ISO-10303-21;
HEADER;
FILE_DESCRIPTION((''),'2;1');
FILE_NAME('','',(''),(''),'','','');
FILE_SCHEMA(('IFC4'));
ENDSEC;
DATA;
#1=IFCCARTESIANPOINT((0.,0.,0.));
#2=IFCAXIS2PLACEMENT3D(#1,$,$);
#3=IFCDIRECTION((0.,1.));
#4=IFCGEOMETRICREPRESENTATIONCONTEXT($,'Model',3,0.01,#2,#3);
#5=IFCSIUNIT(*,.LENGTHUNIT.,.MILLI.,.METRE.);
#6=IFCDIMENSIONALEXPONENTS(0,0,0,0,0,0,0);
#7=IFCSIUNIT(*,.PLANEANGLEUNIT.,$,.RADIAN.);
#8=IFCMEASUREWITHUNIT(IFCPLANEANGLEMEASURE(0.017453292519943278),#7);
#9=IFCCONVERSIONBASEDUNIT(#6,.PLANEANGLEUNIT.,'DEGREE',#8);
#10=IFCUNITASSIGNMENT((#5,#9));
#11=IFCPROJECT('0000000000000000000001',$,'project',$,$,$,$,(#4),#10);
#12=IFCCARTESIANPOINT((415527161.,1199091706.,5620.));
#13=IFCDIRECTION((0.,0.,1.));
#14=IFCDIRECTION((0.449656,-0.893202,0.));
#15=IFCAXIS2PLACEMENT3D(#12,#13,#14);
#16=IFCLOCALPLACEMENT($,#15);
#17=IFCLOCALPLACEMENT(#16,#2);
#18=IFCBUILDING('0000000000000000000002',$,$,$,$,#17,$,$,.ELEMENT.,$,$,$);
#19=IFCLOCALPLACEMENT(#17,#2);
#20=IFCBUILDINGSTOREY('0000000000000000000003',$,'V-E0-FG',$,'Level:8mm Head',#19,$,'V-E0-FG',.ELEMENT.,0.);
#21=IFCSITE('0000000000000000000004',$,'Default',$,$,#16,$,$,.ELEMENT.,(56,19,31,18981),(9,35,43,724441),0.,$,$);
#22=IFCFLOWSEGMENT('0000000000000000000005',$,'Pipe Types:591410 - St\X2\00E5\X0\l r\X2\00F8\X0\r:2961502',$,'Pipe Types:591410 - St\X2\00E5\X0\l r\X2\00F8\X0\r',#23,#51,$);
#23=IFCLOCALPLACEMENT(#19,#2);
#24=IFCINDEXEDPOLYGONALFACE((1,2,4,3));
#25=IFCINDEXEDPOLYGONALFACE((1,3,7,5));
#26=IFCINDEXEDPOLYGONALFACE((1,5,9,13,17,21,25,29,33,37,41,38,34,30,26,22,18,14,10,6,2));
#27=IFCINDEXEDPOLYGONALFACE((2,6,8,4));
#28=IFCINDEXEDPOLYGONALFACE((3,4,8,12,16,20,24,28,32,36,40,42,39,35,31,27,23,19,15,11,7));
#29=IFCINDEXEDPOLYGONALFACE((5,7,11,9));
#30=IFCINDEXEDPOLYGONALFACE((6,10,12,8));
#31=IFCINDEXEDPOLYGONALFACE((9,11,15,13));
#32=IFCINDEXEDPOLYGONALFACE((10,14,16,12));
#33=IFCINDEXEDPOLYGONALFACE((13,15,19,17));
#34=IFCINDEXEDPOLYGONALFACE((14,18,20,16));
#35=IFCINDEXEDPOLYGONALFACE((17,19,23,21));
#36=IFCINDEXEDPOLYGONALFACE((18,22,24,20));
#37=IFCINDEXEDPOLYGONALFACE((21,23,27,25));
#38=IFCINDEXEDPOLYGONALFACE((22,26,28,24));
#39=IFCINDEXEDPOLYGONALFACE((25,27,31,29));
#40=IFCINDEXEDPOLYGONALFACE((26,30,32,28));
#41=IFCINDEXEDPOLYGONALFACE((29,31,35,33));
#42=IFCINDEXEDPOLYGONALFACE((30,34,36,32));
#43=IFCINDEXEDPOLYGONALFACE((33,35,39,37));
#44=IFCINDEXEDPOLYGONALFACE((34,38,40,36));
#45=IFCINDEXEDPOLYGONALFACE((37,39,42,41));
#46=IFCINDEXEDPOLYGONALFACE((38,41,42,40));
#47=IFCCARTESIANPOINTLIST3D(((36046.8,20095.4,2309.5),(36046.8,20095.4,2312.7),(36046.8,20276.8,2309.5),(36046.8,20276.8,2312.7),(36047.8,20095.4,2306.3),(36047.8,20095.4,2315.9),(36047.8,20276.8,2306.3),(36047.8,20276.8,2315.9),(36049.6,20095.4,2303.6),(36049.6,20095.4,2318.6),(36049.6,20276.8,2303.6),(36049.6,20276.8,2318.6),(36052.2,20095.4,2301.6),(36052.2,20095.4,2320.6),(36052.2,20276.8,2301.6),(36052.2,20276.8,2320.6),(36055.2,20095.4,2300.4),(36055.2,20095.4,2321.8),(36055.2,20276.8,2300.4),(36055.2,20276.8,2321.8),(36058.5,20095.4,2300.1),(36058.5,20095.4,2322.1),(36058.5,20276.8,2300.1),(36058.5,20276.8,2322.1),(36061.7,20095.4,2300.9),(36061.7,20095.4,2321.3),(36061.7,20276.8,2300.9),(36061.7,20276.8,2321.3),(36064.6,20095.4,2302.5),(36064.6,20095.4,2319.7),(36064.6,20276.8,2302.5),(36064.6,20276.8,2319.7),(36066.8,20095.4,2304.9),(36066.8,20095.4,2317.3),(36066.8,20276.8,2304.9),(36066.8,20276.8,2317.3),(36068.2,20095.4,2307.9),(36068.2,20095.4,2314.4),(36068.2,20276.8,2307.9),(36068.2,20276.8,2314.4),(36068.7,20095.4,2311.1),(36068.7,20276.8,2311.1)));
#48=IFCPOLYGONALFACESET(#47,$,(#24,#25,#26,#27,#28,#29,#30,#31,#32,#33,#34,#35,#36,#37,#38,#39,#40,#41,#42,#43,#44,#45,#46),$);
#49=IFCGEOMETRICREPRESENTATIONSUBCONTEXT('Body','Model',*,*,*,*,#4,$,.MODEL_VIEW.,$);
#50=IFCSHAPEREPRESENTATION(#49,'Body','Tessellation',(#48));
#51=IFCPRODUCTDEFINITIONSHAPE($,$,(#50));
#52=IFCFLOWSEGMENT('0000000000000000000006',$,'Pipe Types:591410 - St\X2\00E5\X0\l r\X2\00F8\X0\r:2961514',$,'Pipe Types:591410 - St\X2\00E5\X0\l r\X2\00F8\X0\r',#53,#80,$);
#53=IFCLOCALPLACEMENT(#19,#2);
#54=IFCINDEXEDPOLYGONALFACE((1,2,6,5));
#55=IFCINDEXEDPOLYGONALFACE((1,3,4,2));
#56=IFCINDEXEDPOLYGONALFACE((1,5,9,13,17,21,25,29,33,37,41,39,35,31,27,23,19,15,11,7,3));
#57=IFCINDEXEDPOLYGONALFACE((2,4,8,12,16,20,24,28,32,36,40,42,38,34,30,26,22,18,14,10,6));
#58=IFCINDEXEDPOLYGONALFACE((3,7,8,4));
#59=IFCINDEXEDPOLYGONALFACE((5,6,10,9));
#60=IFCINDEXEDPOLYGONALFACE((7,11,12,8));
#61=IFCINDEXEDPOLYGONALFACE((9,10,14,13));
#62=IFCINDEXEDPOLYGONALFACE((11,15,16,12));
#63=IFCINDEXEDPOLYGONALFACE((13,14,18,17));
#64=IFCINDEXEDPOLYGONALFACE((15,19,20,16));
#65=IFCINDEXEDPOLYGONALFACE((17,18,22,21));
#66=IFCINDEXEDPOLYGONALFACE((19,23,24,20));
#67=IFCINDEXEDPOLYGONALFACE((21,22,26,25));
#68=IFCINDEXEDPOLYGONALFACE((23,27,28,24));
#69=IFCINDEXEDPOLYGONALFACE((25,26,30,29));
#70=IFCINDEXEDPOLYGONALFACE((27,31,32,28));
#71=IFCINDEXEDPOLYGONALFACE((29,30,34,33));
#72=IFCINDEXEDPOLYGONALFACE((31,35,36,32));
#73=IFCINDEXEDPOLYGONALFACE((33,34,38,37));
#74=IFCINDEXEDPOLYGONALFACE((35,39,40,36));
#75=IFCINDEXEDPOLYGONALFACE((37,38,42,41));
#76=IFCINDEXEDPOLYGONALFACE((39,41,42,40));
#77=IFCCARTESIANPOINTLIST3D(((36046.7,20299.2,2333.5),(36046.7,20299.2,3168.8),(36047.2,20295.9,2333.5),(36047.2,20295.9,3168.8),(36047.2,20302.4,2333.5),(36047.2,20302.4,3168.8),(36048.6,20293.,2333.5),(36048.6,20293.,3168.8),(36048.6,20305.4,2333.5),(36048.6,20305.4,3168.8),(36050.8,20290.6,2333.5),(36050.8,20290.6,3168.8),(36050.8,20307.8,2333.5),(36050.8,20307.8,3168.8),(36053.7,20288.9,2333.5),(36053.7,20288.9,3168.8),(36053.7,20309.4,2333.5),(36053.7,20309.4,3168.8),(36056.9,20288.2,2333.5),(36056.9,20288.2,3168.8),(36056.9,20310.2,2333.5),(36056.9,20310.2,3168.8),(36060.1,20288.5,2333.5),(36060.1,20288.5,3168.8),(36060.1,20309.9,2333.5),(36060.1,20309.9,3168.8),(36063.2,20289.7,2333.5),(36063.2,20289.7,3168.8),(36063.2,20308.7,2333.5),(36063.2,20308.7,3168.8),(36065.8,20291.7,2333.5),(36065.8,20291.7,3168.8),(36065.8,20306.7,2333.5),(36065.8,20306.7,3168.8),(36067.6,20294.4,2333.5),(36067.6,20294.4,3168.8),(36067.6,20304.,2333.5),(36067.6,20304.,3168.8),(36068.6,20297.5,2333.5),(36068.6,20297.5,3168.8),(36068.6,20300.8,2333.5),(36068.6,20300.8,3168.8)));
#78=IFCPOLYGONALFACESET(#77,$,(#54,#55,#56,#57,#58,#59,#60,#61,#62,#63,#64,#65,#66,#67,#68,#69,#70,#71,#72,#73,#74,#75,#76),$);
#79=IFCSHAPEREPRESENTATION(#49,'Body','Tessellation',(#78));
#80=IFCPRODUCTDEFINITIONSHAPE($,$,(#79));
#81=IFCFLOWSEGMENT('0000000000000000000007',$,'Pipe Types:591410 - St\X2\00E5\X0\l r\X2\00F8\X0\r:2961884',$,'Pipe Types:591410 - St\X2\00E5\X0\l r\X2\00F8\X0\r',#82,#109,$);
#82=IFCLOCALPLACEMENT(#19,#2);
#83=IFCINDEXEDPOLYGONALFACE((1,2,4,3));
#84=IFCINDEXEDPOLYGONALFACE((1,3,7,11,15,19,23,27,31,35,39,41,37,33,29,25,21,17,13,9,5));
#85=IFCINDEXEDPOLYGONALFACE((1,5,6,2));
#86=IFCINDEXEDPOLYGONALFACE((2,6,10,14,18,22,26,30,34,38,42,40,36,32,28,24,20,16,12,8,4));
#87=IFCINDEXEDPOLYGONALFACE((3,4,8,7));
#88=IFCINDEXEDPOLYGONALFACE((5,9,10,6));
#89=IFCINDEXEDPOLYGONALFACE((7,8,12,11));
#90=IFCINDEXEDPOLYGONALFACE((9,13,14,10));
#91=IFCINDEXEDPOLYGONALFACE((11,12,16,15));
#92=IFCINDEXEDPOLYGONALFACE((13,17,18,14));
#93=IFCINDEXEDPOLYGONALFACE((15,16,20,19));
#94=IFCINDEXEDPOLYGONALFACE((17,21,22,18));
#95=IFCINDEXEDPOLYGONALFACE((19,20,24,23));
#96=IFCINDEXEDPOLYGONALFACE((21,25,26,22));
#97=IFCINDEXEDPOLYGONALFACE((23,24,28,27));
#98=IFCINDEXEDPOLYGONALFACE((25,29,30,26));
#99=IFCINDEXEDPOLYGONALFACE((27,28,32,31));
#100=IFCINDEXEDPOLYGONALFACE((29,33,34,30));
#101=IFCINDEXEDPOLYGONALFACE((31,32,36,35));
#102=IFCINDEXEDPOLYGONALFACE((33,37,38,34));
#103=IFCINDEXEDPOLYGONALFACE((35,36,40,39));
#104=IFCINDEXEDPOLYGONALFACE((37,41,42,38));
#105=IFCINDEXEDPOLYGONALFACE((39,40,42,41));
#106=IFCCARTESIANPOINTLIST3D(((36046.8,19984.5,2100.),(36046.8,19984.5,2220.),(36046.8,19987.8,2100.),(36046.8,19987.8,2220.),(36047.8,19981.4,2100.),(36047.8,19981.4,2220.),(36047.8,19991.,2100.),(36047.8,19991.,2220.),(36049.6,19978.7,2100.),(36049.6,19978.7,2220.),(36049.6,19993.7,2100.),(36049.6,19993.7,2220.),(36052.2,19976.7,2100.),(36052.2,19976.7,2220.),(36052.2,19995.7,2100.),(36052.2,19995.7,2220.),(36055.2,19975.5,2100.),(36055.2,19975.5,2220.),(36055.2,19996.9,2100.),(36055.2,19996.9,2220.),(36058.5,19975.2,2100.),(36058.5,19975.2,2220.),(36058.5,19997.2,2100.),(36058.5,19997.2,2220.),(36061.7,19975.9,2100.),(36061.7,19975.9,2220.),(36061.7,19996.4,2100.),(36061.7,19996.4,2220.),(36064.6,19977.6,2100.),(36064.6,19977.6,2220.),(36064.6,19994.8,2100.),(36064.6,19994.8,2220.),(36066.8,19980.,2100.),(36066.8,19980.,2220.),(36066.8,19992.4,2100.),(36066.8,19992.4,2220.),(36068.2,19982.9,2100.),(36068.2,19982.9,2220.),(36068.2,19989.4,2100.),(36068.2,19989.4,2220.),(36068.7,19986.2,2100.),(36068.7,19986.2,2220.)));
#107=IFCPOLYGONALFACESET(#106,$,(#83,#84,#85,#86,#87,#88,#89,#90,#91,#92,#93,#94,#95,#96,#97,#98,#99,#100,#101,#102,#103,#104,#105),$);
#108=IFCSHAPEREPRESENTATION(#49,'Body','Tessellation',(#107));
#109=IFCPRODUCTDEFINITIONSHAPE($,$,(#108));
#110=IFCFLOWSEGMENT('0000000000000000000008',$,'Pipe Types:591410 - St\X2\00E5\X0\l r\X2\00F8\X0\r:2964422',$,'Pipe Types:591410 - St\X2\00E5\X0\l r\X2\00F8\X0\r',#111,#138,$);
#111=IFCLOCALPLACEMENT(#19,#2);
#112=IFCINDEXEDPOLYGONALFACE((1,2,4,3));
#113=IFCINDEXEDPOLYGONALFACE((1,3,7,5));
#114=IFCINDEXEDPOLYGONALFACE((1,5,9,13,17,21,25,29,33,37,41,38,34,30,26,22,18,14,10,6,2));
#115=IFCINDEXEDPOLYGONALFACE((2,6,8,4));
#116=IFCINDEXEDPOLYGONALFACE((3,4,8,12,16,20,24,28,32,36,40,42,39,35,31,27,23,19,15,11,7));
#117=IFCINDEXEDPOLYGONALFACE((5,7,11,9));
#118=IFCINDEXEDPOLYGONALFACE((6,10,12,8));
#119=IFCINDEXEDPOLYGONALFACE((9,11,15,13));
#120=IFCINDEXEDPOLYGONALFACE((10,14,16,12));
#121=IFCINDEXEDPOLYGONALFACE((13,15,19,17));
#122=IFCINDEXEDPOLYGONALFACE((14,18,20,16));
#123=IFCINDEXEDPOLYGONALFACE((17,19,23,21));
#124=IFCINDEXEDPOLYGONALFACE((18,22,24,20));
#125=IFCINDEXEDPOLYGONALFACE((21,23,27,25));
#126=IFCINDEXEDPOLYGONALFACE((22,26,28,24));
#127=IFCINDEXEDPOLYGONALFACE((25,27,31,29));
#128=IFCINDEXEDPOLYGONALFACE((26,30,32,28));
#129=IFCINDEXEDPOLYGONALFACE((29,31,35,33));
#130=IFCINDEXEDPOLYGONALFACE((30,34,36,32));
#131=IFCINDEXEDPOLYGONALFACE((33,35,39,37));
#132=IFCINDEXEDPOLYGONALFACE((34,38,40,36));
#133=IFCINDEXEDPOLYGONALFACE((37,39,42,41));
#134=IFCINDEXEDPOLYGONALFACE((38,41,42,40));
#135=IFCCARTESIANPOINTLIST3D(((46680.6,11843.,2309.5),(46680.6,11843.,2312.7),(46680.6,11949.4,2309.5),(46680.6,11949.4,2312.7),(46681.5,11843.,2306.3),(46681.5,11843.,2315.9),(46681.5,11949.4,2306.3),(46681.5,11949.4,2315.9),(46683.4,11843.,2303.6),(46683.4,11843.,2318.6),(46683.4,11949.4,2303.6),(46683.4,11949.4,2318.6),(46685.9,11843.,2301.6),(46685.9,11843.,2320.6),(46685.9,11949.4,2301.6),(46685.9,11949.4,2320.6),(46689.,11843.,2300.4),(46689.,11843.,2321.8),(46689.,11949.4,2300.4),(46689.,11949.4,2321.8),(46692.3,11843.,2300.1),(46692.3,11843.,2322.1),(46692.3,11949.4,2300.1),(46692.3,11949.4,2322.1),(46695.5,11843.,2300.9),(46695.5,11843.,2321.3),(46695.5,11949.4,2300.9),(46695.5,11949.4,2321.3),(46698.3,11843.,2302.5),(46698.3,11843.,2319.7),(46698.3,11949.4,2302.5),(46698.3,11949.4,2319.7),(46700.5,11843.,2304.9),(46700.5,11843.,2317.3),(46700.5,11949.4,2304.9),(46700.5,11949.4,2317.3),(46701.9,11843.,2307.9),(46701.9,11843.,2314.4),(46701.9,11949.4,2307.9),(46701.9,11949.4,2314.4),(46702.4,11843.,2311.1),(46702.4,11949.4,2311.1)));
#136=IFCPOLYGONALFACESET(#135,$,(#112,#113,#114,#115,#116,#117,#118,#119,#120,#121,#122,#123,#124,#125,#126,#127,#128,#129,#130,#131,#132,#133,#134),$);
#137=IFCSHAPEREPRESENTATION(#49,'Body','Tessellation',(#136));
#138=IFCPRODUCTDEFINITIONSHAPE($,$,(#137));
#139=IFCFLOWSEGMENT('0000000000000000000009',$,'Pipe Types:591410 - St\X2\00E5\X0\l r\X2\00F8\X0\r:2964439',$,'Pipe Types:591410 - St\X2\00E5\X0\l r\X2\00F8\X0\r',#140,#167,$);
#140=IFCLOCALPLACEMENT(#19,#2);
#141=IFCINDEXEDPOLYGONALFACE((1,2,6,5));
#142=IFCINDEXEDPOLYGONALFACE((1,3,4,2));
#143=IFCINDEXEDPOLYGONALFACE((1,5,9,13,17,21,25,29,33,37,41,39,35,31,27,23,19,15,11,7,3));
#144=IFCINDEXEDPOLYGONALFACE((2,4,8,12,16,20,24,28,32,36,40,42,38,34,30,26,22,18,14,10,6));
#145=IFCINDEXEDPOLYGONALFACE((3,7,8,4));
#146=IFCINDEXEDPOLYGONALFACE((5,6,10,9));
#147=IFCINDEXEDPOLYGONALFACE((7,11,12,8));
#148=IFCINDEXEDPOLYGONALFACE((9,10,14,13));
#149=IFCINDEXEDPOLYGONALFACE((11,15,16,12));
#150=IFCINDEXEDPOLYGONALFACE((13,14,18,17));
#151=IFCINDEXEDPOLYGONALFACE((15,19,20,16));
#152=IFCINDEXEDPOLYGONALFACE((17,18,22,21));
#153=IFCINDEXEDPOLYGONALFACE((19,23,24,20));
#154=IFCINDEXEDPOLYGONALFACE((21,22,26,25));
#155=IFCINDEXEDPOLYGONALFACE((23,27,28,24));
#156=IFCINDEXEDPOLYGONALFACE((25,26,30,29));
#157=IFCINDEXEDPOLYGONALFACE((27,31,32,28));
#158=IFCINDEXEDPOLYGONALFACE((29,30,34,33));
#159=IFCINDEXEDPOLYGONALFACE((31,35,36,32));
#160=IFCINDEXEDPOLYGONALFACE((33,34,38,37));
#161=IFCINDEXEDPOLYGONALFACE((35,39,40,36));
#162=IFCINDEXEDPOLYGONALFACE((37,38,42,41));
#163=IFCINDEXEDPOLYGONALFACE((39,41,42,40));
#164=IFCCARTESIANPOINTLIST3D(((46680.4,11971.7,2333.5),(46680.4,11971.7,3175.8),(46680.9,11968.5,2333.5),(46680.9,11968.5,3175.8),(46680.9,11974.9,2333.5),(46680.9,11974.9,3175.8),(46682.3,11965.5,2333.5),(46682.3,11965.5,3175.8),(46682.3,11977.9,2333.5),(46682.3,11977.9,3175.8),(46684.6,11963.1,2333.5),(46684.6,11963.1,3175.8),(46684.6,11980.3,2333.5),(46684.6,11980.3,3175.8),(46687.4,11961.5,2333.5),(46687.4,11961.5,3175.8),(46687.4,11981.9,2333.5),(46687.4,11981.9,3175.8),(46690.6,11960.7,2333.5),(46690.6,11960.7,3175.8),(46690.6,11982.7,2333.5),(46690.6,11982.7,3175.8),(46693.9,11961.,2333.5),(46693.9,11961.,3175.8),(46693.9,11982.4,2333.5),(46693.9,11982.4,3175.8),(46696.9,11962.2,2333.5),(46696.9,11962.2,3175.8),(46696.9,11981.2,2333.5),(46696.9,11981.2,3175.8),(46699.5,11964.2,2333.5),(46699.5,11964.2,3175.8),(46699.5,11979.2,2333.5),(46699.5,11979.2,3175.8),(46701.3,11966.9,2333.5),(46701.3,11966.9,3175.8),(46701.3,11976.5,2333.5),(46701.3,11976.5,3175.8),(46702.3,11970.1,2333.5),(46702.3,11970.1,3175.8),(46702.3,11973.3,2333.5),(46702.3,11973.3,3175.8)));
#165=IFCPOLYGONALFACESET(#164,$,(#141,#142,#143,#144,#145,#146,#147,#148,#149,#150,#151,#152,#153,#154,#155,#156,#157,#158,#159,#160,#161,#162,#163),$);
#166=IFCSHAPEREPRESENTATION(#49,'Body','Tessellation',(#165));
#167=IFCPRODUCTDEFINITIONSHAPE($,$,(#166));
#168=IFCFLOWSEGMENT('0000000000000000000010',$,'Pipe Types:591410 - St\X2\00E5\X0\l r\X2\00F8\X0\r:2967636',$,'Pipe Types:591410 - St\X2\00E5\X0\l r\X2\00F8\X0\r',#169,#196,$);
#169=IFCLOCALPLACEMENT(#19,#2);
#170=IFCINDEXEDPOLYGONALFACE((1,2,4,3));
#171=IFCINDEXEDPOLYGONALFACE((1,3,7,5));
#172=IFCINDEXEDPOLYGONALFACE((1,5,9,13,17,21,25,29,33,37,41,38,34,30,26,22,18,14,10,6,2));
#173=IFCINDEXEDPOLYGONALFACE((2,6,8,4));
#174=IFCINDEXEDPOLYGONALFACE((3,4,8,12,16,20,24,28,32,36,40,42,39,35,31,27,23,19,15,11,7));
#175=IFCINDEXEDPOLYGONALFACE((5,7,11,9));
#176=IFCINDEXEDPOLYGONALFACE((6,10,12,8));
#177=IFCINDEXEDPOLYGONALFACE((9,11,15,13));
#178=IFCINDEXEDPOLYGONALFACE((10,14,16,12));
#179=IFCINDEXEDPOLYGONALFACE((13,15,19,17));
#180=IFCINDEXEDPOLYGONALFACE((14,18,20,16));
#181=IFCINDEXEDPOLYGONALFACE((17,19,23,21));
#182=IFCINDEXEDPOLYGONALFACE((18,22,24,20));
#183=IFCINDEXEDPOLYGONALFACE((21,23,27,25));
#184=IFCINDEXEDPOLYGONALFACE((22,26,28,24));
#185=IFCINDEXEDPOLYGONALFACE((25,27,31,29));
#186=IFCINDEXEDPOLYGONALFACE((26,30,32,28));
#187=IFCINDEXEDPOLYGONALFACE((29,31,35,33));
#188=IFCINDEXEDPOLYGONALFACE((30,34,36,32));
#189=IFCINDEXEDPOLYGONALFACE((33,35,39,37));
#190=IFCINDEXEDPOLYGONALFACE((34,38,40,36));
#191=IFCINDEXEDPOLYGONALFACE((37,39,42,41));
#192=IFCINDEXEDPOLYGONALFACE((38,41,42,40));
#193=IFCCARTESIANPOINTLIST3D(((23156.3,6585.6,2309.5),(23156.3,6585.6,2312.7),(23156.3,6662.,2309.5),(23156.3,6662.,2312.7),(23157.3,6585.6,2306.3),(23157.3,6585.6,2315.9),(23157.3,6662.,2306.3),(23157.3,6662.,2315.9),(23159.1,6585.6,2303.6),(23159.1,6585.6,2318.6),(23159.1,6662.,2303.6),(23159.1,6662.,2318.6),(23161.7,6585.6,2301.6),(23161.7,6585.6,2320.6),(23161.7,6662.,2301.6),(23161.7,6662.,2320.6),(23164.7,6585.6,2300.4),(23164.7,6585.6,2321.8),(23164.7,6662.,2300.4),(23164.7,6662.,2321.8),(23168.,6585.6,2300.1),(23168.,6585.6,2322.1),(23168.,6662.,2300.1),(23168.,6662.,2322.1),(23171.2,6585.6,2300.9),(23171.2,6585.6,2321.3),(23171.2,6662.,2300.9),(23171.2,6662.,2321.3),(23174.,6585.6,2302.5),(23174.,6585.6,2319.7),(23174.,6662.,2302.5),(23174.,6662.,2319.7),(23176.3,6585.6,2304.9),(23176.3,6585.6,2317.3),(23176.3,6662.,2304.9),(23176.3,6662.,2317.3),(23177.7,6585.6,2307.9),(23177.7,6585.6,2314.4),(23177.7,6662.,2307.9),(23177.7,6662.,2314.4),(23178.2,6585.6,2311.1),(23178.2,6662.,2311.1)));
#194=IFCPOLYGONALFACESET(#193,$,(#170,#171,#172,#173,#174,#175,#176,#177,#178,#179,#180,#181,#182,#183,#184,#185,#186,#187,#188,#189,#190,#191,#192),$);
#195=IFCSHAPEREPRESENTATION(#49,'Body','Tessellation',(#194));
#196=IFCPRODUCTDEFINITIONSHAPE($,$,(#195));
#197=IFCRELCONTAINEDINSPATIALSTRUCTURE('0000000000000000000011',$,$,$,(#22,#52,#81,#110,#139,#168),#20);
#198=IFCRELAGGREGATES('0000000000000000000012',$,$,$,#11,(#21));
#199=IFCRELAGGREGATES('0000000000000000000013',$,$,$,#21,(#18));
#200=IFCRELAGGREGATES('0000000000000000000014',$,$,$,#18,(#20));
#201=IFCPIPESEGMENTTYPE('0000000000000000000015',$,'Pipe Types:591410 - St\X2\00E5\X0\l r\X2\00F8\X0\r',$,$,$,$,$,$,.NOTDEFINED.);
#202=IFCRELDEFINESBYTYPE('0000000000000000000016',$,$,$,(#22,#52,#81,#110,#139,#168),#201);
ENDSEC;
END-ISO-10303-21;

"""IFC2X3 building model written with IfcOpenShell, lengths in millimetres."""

from ifc_helpers import new_model, entity, si_unit, converted_unit, direction, frame, frame_2d, origin, origin_2d_with_axis, place, context, subcontext, project, spatial, circle, extrude, type_object, element, save


model = new_model("IFC2X3")

# Units and contexts
model_context = context("Model", 3, precision=0.01, world=origin(), true_north=direction((0.0, 1.0)))
body_context = subcontext(model_context, "Body", "Model", "MODEL_VIEW")
ifc_project = project(units=[si_unit("LENGTHUNIT", "METRE", prefix="MILLI"), converted_unit("PLANEANGLEUNIT", "DEGREE", entity("IfcPlaneAngleMeasure", 0.017453292519943278), si_unit("PLANEANGLEUNIT", "RADIAN"), dimensions=[0, 0, 0, 0, 0, 0, 0])], contexts=[model_context])

# Site, building, storey
site_placement = place(None, frame((415527161.0, 1199091706.0, 5620.0), z_axis=(0.0, 0.0, 1.0), x_axis=(0.449656, -0.893202, 0.0)))
site = spatial("IfcSite", under=ifc_project, at=site_placement, Name="Default", CompositionType="ELEMENT", RefLatitude=(56, 19, 31, 18981), RefLongitude=(9, 35, 43, 724441), RefElevation=0.0)
building_placement = place(site_placement, origin())
building = spatial("IfcBuilding", under=site, at=building_placement, CompositionType="ELEMENT")
storey_placement = place(building_placement, origin())
storey = spatial("IfcBuildingStorey", under=building, at=storey_placement, Name="V-E0-FG", ObjectType="Level:8mm Head", LongName="V-E0-FG", CompositionType="ELEMENT", Elevation=0.0)

# Flow segments
pipe_segment_type_1 = type_object("IfcPipeSegmentType", Name="Pipe Types:591410 - Stål rør", PredefinedType="NOTDEFINED")
flow_segment_1_placement = place(storey_placement, origin())
element("IfcFlowSegment", 1, at=flow_segment_1_placement, inside=storey, type_object=pipe_segment_type_1, Name="Pipe Types:591410 - Stål rør:2961502", ObjectType="Pipe Types:591410 - Stål rør", context=body_context, shape_type="SweptSolid", body=[
    extrude(circle(Radius=11.0, at=frame_2d((0.0, 0.0), x_axis=(1.0, 0.0))), frame((36057.7, 20095.4, 2311.1), z_axis=(0.0, 1.0, 0.0), x_axis=(1.0, 0.0, 0.0)), (0.0, 0.0, 1.0), 181.4),
])
flow_segment_2_placement = place(storey_placement, origin())
element("IfcFlowSegment", 2, at=flow_segment_2_placement, inside=storey, type_object=pipe_segment_type_1, Name="Pipe Types:591410 - Stål rør:2961514", ObjectType="Pipe Types:591410 - Stål rør", context=body_context, shape_type="SweptSolid", body=[
    extrude(circle(Radius=11.0, at=origin_2d_with_axis()), frame((36057.7, 20299.2, 2333.5), z_axis=(0.0, 0.0, 1.0), x_axis=(-1.0, 0.0, 0.0)), (0.0, 0.0, 1.0), 835.3),
])
flow_segment_3_placement = place(storey_placement, origin())
element("IfcFlowSegment", 3, at=flow_segment_3_placement, inside=storey, type_object=pipe_segment_type_1, Name="Pipe Types:591410 - Stål rør:2961884", ObjectType="Pipe Types:591410 - Stål rør", context=body_context, shape_type="SweptSolid", body=[
    extrude(circle(Radius=11.0, at=frame_2d((0.0, 0.0), x_axis=(1.0, 0.0))), frame((36057.7, 19986.2, 2100.0)), (0.0, 0.0, 1.0), 120.0),
])
flow_segment_4_placement = place(storey_placement, origin())
element("IfcFlowSegment", 4, at=flow_segment_4_placement, inside=storey, type_object=pipe_segment_type_1, Name="Pipe Types:591410 - Stål rør:2964422", ObjectType="Pipe Types:591410 - Stål rør", context=body_context, shape_type="SweptSolid", body=[
    extrude(circle(Radius=11.0, at=origin_2d_with_axis()), frame((46691.4, 11843.0, 2311.1), z_axis=(0.0, 1.0, 0.0), x_axis=(1.0, 0.0, 0.0)), (0.0, 0.0, 1.0), 106.4),
])
flow_segment_5_placement = place(storey_placement, origin())
element("IfcFlowSegment", 5, at=flow_segment_5_placement, inside=storey, type_object=pipe_segment_type_1, Name="Pipe Types:591410 - Stål rør:2964439", ObjectType="Pipe Types:591410 - Stål rør", context=body_context, shape_type="SweptSolid", body=[
    extrude(circle(Radius=11.0, at=origin_2d_with_axis()), frame((46691.4, 11971.7, 2333.5), z_axis=(0.0, 0.0, 1.0), x_axis=(-1.0, 0.0, 0.0)), (0.0, 0.0, 1.0), 842.3),
])
flow_segment_6_placement = place(storey_placement, origin())
element("IfcFlowSegment", 6, at=flow_segment_6_placement, inside=storey, type_object=pipe_segment_type_1, Name="Pipe Types:591410 - Stål rør:2967636", ObjectType="Pipe Types:591410 - Stål rør", context=body_context, shape_type="SweptSolid", body=[
    extrude(circle(Radius=11.0, at=origin_2d_with_axis()), frame((23167.2, 6585.6, 2311.1), z_axis=(0.0, 1.0, 0.0), x_axis=(1.0, 0.0, 0.0)), (0.0, 0.0, 1.0), 76.4),
])

save(model, "model.ifc")
